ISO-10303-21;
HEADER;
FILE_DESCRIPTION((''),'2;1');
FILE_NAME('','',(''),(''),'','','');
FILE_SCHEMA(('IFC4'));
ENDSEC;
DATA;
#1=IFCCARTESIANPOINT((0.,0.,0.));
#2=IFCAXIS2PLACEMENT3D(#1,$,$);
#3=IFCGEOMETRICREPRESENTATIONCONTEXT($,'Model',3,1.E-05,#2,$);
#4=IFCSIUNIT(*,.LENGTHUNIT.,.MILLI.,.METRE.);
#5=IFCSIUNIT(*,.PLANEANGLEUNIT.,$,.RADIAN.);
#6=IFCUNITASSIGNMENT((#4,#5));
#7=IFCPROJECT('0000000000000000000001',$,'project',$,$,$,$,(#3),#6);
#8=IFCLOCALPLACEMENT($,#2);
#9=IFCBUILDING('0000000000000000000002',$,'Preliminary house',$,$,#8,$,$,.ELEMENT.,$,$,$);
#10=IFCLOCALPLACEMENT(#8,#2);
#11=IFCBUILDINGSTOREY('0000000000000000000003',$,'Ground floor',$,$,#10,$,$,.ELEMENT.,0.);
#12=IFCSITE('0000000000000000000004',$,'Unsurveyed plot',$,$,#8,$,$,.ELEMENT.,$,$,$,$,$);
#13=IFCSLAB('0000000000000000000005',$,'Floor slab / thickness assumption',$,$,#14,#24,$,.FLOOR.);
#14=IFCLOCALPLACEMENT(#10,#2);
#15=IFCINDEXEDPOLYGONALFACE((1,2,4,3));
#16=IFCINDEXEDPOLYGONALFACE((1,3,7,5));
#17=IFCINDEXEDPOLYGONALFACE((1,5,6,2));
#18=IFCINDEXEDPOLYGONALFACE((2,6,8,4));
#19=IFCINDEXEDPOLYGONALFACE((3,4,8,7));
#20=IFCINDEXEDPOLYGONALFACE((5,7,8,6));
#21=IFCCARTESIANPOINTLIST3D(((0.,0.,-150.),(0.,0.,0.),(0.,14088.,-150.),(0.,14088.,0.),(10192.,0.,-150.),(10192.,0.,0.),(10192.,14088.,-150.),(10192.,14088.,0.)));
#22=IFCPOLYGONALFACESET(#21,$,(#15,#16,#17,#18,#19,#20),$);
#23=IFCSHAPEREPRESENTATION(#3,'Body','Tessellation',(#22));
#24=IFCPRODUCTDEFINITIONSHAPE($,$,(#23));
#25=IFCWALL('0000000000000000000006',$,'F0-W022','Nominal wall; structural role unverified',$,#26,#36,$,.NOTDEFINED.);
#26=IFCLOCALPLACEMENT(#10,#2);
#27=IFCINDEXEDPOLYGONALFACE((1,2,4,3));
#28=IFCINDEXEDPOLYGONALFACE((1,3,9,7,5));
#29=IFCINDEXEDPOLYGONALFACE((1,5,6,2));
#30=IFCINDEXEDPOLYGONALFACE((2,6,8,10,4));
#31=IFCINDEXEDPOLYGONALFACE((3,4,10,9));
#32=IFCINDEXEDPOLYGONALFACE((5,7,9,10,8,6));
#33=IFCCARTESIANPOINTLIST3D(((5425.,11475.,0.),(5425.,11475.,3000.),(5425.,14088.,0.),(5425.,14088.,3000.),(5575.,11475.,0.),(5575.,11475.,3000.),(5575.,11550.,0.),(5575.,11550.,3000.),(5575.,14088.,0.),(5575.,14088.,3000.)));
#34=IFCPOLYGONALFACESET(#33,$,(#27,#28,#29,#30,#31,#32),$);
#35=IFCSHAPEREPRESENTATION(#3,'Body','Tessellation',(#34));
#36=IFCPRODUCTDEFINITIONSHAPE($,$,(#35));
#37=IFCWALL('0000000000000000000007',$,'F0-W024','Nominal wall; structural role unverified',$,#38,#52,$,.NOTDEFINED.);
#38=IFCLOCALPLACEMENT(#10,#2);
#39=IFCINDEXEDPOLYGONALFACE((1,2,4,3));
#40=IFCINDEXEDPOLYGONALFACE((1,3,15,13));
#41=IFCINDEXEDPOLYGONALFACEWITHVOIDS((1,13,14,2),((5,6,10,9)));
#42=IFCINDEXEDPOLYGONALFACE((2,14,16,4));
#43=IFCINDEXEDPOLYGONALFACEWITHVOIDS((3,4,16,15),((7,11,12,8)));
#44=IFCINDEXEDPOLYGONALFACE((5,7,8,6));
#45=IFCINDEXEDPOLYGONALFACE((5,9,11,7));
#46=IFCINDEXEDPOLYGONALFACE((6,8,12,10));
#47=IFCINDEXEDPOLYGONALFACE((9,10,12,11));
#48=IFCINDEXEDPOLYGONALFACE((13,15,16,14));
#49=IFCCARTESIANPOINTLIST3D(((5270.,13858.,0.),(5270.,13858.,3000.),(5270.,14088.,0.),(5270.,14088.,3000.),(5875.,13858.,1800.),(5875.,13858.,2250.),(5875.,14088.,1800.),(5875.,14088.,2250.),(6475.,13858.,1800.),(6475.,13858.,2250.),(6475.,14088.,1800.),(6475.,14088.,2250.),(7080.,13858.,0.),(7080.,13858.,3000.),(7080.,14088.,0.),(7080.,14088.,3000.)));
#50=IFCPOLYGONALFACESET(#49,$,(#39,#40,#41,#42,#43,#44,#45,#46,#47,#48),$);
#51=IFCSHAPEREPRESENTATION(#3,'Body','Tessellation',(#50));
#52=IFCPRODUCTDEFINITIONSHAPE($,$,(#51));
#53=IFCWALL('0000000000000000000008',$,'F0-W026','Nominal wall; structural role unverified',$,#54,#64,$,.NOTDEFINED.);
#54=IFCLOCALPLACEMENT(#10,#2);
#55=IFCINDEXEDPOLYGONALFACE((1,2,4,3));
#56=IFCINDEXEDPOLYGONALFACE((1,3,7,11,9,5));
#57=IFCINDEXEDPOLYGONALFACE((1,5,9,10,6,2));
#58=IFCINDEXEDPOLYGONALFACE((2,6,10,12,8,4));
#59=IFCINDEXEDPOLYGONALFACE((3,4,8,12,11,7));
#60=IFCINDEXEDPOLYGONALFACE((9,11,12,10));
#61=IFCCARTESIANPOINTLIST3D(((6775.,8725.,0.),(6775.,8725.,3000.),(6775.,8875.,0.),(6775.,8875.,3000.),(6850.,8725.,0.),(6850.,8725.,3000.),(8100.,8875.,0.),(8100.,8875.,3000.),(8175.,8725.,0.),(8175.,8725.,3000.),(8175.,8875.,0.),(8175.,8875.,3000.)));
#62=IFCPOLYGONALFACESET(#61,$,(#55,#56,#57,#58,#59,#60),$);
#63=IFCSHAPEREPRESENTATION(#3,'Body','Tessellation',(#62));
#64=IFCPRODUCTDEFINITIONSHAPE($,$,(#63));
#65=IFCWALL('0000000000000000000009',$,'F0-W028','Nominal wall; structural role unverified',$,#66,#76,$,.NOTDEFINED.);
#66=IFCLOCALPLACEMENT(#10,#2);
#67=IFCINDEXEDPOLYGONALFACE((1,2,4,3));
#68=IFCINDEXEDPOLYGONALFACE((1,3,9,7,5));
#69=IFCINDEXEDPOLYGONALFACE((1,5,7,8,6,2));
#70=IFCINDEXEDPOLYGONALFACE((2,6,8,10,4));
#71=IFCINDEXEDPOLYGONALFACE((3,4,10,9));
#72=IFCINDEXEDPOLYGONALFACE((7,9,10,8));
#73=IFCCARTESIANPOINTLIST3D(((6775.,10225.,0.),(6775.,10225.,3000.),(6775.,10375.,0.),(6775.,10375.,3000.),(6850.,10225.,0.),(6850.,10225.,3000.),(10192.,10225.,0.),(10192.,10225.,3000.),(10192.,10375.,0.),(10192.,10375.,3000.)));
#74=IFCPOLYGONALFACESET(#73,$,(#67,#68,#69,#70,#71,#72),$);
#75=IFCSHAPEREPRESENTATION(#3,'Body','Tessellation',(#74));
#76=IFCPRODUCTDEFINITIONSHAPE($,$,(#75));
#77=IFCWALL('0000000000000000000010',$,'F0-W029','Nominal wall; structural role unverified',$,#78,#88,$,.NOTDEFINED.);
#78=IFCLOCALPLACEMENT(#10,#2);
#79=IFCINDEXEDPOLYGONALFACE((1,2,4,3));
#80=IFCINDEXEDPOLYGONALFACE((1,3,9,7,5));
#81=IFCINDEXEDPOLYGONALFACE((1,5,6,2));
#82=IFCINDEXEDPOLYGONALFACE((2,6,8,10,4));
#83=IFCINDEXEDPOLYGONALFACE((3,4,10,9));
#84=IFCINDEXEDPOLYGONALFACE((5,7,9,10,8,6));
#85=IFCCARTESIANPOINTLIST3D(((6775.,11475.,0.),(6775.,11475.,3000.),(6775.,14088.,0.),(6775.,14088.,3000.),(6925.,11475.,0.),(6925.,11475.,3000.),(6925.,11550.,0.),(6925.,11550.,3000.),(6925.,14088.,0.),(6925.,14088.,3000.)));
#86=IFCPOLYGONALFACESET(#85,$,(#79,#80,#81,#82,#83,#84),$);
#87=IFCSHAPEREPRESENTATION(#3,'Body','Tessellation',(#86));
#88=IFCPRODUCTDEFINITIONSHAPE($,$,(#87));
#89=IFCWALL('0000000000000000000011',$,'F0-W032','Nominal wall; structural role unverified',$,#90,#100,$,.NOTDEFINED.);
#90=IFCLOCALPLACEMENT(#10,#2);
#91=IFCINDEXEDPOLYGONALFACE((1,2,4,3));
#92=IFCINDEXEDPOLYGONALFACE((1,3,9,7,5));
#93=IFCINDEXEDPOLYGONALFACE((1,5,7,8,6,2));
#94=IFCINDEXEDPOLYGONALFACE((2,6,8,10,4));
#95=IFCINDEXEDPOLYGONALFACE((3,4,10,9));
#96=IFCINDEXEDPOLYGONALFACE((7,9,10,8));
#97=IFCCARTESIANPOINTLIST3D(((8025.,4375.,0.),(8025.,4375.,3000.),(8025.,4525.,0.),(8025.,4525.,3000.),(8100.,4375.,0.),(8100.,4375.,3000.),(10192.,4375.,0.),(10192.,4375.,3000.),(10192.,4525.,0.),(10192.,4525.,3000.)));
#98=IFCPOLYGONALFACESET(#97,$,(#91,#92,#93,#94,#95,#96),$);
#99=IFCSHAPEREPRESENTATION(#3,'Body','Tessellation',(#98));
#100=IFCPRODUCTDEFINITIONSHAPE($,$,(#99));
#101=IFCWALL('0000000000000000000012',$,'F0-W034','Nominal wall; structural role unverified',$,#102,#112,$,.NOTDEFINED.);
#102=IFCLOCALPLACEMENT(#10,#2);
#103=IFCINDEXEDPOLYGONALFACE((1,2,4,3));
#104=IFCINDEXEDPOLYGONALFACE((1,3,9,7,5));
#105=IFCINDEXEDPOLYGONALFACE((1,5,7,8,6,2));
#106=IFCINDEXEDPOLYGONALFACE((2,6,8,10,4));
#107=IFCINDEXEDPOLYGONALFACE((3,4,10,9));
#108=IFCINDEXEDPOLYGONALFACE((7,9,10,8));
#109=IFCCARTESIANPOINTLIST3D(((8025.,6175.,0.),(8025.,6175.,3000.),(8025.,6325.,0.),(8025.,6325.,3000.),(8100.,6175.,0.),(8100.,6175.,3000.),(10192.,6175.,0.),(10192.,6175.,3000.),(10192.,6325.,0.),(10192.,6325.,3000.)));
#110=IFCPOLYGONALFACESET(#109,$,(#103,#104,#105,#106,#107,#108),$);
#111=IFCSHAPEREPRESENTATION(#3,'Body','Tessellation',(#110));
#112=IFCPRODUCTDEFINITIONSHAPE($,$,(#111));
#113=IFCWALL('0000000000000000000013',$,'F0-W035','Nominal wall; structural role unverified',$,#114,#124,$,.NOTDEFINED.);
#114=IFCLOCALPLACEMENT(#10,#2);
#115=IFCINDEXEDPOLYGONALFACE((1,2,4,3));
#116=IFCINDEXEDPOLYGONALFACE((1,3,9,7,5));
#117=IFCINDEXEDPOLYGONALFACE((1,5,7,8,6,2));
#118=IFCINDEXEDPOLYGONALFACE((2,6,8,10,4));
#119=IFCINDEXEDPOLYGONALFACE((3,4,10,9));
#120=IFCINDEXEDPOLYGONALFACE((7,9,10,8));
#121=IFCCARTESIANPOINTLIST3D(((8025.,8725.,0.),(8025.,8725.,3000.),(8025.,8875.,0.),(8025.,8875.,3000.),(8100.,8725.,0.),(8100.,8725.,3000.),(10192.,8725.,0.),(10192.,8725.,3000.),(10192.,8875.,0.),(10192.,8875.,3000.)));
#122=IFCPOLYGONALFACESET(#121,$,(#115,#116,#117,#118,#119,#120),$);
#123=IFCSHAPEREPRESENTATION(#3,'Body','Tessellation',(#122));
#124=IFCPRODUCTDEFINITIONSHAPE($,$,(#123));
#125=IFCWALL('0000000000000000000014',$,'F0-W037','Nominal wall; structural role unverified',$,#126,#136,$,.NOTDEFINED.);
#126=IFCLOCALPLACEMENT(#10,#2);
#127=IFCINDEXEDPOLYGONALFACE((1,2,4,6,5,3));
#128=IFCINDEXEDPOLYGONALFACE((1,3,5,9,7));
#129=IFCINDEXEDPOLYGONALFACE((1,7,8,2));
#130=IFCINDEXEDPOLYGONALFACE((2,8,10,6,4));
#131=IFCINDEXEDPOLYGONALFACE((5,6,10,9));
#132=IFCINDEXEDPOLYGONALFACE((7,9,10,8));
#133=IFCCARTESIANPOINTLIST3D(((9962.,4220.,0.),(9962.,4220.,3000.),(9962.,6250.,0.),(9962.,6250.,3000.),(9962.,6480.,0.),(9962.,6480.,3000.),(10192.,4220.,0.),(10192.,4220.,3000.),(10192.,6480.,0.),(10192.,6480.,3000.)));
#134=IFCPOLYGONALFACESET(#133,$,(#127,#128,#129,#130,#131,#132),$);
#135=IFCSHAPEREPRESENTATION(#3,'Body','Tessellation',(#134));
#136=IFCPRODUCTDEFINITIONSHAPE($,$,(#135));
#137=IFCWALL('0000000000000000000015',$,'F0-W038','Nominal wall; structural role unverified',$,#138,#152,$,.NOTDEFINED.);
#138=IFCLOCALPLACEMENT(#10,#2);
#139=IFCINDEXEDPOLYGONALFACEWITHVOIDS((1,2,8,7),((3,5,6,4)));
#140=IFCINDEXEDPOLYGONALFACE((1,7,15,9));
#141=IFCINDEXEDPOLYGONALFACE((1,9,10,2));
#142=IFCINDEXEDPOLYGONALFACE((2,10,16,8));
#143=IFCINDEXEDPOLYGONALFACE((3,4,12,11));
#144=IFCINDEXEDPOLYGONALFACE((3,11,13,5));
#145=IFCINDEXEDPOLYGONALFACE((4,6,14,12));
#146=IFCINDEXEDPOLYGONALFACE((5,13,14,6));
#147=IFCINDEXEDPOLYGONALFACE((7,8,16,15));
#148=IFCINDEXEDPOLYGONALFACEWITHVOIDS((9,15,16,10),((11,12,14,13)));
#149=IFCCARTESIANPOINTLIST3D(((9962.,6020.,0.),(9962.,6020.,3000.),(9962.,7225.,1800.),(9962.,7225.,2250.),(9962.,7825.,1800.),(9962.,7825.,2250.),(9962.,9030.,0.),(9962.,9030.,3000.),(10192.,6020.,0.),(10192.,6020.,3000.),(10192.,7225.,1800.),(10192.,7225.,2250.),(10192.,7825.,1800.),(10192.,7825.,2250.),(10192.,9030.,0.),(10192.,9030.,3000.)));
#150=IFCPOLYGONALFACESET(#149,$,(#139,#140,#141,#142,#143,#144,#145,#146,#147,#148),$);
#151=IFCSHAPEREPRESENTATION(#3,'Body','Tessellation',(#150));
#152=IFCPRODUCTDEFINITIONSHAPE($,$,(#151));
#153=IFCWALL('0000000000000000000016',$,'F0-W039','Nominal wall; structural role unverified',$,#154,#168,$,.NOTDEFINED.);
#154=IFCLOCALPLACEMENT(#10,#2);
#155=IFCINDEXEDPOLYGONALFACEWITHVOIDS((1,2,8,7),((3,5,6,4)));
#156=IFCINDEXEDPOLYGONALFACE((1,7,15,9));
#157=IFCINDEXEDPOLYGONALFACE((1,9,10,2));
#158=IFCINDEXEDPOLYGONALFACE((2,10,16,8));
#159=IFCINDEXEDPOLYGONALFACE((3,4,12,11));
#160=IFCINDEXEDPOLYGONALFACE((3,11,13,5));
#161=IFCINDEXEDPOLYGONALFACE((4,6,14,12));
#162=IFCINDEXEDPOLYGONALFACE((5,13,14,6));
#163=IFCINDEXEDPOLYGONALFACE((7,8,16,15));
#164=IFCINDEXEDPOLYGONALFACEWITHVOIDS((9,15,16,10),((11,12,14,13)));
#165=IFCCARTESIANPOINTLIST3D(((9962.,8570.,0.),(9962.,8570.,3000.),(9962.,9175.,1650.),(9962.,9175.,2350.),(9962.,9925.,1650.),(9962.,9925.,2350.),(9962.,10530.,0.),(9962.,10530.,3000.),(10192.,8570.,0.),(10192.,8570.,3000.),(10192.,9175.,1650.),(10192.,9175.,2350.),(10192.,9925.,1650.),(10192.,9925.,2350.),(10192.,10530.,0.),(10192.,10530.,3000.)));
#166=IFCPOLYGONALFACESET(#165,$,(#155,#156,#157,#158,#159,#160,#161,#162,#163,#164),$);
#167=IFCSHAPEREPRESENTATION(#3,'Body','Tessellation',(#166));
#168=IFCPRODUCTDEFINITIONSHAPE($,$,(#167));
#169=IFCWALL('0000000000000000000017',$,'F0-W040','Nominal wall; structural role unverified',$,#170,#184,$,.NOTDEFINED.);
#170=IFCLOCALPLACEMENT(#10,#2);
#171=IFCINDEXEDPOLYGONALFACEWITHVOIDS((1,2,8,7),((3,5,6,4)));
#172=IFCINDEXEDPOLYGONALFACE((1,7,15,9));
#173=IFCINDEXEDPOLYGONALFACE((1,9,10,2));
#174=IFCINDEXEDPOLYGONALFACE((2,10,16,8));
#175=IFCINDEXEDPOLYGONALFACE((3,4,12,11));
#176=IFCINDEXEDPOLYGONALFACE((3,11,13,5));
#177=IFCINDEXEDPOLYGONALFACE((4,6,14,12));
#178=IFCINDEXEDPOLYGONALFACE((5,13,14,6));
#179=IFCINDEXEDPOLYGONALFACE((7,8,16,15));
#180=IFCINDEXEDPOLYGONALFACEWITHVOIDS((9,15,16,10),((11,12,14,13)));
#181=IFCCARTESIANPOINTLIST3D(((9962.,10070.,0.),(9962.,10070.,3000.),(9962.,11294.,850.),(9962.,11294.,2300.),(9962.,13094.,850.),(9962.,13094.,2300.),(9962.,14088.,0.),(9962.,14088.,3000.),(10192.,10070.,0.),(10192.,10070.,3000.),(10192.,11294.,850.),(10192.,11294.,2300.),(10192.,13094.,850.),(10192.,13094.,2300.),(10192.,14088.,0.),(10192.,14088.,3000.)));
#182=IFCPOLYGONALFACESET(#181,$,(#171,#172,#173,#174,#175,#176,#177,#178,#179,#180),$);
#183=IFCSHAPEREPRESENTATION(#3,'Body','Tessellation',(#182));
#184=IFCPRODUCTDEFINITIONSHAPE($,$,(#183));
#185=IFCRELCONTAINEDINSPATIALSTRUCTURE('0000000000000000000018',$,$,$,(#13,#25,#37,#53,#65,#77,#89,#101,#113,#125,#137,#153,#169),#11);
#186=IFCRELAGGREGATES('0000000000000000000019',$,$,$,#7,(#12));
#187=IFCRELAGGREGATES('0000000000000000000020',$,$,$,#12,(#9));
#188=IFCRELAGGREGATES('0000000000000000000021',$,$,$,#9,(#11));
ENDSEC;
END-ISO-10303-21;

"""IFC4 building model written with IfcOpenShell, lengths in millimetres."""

from ifc_helpers import new_model, si_unit, frame, origin, place, context, project, spatial, polyline, outline, extrude, element, save


model = new_model("IFC4")

# Units and contexts
model_context = context("Model", 3, precision=1e-05, world=origin())
ifc_project = project(units=[si_unit("LENGTHUNIT", "METRE", prefix="MILLI"), si_unit("PLANEANGLEUNIT", "RADIAN")], contexts=[model_context])

# Site, building, storey
placement_1 = place(None, origin())
site = spatial("IfcSite", under=ifc_project, at=placement_1, Name="Unsurveyed plot", CompositionType="ELEMENT")
building = spatial("IfcBuilding", under=site, at=placement_1, Name="Preliminary house", CompositionType="ELEMENT")
placement_2 = place(placement_1, origin())
storey = spatial("IfcBuildingStorey", under=building, at=placement_2, Name="Ground floor", CompositionType="ELEMENT", Elevation=0.0)

# Slab
element("IfcSlab", 1, at=placement_2, inside=storey, Name="Floor slab / thickness assumption", PredefinedType="FLOOR", context=model_context, shape_type="SweptSolid", body=[
    extrude(outline(polyline([(10192.0, 0.0), (10192.0, 14088.0), (0.0, 14088.0), (0.0, 0.0), (10192.0, 0.0)])), frame((0.0, 0.0, -150.0)), (0.0, 0.0, 1.0), 150.0),
])

# Wall
element("IfcWall", 2, at=placement_2, inside=storey, Name="F0-W022", Description="Nominal wall; structural role unverified", PredefinedType="NOTDEFINED", context=model_context, shape_type="SweptSolid", body=[
    extrude(outline(polyline([(5575.0, 11550.0), (5575.0, 11475.0), (5425.0, 11475.0), (5425.0, 14088.0), (5575.0, 14088.0), (5575.0, 11550.0)])), origin(), (0.0, 0.0, 1.0), 3000.0),
])

# Wall, opening
wall_1 = element("IfcWall", 3, at=placement_2, inside=storey, Name="F0-W024", Description="Nominal wall; structural role unverified", PredefinedType="NOTDEFINED", context=model_context, shape_type="SweptSolid", body=[
    extrude(outline(polyline([(7080.0, 13858.0), (5500.0, 13858.0), (5270.0, 13858.0), (5270.0, 14088.0), (7080.0, 14088.0), (7080.0, 13858.0)])), origin(), (0.0, 0.0, 1.0), 3000.0),
])
element("IfcOpeningElement", 4, at=placement_2, cuts=wall_1, PredefinedType="OPENING", context=model_context, shape_type="SweptSolid", body=[
    extrude(outline(polyline([(5875.0, 13443.0), (6475.0, 13443.0), (6475.0, 14503.0), (5875.0, 14503.0), (5875.0, 13443.0)])), frame((0.0, 0.0, 1800.0)), (0.0, 0.0, 1.0), 450.0),
])

# Wall
element("IfcWall", 5, at=placement_2, inside=storey, Name="F0-W026", Description="Nominal wall; structural role unverified", PredefinedType="NOTDEFINED", context=model_context, shape_type="SweptSolid", body=[
    extrude(outline(polyline([(8175.0, 8875.0), (8175.0, 8725.0), (6850.0, 8725.0), (6775.0, 8725.0), (6775.0, 8875.0), (8100.0, 8875.0), (8175.0, 8875.0)])), origin(), (0.0, 0.0, 1.0), 3000.0),
])

# Walls
element("IfcWall", 6, at=placement_2, inside=storey, Name="F0-W028", Description="Nominal wall; structural role unverified", PredefinedType="NOTDEFINED", context=model_context, shape_type="SweptSolid", body=[
    extrude(outline(polyline([(6850.0, 10225.0), (6775.0, 10225.0), (6775.0, 10375.0), (10192.0, 10375.0), (10192.0, 10225.0), (6850.0, 10225.0)])), origin(), (0.0, 0.0, 1.0), 3000.0),
])
element("IfcWall", 7, at=placement_2, inside=storey, Name="F0-W029", Description="Nominal wall; structural role unverified", PredefinedType="NOTDEFINED", context=model_context, shape_type="SweptSolid", body=[
    extrude(outline(polyline([(6925.0, 11550.0), (6925.0, 11475.0), (6775.0, 11475.0), (6775.0, 14088.0), (6925.0, 14088.0), (6925.0, 11550.0)])), origin(), (0.0, 0.0, 1.0), 3000.0),
])

# Wall
element("IfcWall", 8, at=placement_2, inside=storey, Name="F0-W032", Description="Nominal wall; structural role unverified", PredefinedType="NOTDEFINED", context=model_context, shape_type="SweptSolid", body=[
    extrude(outline(polyline([(8100.0, 4375.0), (8025.0, 4375.0), (8025.0, 4525.0), (10192.0, 4525.0), (10192.0, 4375.0), (8100.0, 4375.0)])), origin(), (0.0, 0.0, 1.0), 3000.0),
])

# Walls
element("IfcWall", 9, at=placement_2, inside=storey, Name="F0-W034", Description="Nominal wall; structural role unverified", PredefinedType="NOTDEFINED", context=model_context, shape_type="SweptSolid", body=[
    extrude(outline(polyline([(8100.0, 6175.0), (8025.0, 6175.0), (8025.0, 6325.0), (10192.0, 6325.0), (10192.0, 6175.0), (8100.0, 6175.0)])), origin(), (0.0, 0.0, 1.0), 3000.0),
])
element("IfcWall", 10, at=placement_2, inside=storey, Name="F0-W035", Description="Nominal wall; structural role unverified", PredefinedType="NOTDEFINED", context=model_context, shape_type="SweptSolid", body=[
    extrude(outline(polyline([(8100.0, 8725.0), (8025.0, 8725.0), (8025.0, 8875.0), (10192.0, 8875.0), (10192.0, 8725.0), (8100.0, 8725.0)])), origin(), (0.0, 0.0, 1.0), 3000.0),
])

# Wall
element("IfcWall", 11, at=placement_2, inside=storey, Name="F0-W037", Description="Nominal wall; structural role unverified", PredefinedType="NOTDEFINED", context=model_context, shape_type="SweptSolid", body=[
    extrude(outline(polyline([(9962.0, 6480.0), (10192.0, 6480.0), (10192.0, 4220.0), (9962.0, 4220.0), (9962.0, 6250.0), (9962.0, 6480.0)])), origin(), (0.0, 0.0, 1.0), 3000.0),
])

# Walls, openings
wall_2 = element("IfcWall", 12, at=placement_2, inside=storey, Name="F0-W038", Description="Nominal wall; structural role unverified", PredefinedType="NOTDEFINED", context=model_context, shape_type="SweptSolid", body=[
    extrude(outline(polyline([(9962.0, 9030.0), (10192.0, 9030.0), (10192.0, 6020.0), (9962.0, 6020.0), (9962.0, 8800.0), (9962.0, 9030.0)])), origin(), (0.0, 0.0, 1.0), 3000.0),
])
element("IfcOpeningElement", 13, at=placement_2, cuts=wall_2, PredefinedType="OPENING", context=model_context, shape_type="SweptSolid", body=[
    extrude(outline(polyline([(10607.0, 7225.0), (10607.0, 7825.0), (9547.0, 7825.0), (9547.0, 7225.0), (10607.0, 7225.0)])), frame((0.0, 0.0, 1800.0)), (0.0, 0.0, 1.0), 450.0),
])
wall_3 = element("IfcWall", 14, at=placement_2, inside=storey, Name="F0-W039", Description="Nominal wall; structural role unverified", PredefinedType="NOTDEFINED", context=model_context, shape_type="SweptSolid", body=[
    extrude(outline(polyline([(9962.0, 10530.0), (10192.0, 10530.0), (10192.0, 8570.0), (9962.0, 8570.0), (9962.0, 10300.0), (9962.0, 10530.0)])), origin(), (0.0, 0.0, 1.0), 3000.0),
])
element("IfcOpeningElement", 15, at=placement_2, cuts=wall_3, PredefinedType="OPENING", context=model_context, shape_type="SweptSolid", body=[
    extrude(outline(polyline([(10607.0, 9175.0), (10607.0, 9925.0), (9547.0, 9925.0), (9547.0, 9175.0), (10607.0, 9175.0)])), frame((0.0, 0.0, 1650.0)), (0.0, 0.0, 1.0), 700.0),
])
wall_4 = element("IfcWall", 16, at=placement_2, inside=storey, Name="F0-W040", Description="Nominal wall; structural role unverified", PredefinedType="NOTDEFINED", context=model_context, shape_type="SweptSolid", body=[
    extrude(outline(polyline([(9962.0, 10070.0), (9962.0, 14088.0), (10192.0, 14088.0), (10192.0, 10070.0), (9962.0, 10070.0)])), origin(), (0.0, 0.0, 1.0), 3000.0),
])
element("IfcOpeningElement", 17, at=placement_2, cuts=wall_4, PredefinedType="OPENING", context=model_context, shape_type="SweptSolid", body=[
    extrude(outline(polyline([(10607.0, 11294.0), (10607.0, 13094.0), (9547.0, 13094.0), (9547.0, 11294.0), (10607.0, 11294.0)])), frame((0.0, 0.0, 850.0)), (0.0, 0.0, 1.0), 1450.0),
])

save(model, "model.ifc")
